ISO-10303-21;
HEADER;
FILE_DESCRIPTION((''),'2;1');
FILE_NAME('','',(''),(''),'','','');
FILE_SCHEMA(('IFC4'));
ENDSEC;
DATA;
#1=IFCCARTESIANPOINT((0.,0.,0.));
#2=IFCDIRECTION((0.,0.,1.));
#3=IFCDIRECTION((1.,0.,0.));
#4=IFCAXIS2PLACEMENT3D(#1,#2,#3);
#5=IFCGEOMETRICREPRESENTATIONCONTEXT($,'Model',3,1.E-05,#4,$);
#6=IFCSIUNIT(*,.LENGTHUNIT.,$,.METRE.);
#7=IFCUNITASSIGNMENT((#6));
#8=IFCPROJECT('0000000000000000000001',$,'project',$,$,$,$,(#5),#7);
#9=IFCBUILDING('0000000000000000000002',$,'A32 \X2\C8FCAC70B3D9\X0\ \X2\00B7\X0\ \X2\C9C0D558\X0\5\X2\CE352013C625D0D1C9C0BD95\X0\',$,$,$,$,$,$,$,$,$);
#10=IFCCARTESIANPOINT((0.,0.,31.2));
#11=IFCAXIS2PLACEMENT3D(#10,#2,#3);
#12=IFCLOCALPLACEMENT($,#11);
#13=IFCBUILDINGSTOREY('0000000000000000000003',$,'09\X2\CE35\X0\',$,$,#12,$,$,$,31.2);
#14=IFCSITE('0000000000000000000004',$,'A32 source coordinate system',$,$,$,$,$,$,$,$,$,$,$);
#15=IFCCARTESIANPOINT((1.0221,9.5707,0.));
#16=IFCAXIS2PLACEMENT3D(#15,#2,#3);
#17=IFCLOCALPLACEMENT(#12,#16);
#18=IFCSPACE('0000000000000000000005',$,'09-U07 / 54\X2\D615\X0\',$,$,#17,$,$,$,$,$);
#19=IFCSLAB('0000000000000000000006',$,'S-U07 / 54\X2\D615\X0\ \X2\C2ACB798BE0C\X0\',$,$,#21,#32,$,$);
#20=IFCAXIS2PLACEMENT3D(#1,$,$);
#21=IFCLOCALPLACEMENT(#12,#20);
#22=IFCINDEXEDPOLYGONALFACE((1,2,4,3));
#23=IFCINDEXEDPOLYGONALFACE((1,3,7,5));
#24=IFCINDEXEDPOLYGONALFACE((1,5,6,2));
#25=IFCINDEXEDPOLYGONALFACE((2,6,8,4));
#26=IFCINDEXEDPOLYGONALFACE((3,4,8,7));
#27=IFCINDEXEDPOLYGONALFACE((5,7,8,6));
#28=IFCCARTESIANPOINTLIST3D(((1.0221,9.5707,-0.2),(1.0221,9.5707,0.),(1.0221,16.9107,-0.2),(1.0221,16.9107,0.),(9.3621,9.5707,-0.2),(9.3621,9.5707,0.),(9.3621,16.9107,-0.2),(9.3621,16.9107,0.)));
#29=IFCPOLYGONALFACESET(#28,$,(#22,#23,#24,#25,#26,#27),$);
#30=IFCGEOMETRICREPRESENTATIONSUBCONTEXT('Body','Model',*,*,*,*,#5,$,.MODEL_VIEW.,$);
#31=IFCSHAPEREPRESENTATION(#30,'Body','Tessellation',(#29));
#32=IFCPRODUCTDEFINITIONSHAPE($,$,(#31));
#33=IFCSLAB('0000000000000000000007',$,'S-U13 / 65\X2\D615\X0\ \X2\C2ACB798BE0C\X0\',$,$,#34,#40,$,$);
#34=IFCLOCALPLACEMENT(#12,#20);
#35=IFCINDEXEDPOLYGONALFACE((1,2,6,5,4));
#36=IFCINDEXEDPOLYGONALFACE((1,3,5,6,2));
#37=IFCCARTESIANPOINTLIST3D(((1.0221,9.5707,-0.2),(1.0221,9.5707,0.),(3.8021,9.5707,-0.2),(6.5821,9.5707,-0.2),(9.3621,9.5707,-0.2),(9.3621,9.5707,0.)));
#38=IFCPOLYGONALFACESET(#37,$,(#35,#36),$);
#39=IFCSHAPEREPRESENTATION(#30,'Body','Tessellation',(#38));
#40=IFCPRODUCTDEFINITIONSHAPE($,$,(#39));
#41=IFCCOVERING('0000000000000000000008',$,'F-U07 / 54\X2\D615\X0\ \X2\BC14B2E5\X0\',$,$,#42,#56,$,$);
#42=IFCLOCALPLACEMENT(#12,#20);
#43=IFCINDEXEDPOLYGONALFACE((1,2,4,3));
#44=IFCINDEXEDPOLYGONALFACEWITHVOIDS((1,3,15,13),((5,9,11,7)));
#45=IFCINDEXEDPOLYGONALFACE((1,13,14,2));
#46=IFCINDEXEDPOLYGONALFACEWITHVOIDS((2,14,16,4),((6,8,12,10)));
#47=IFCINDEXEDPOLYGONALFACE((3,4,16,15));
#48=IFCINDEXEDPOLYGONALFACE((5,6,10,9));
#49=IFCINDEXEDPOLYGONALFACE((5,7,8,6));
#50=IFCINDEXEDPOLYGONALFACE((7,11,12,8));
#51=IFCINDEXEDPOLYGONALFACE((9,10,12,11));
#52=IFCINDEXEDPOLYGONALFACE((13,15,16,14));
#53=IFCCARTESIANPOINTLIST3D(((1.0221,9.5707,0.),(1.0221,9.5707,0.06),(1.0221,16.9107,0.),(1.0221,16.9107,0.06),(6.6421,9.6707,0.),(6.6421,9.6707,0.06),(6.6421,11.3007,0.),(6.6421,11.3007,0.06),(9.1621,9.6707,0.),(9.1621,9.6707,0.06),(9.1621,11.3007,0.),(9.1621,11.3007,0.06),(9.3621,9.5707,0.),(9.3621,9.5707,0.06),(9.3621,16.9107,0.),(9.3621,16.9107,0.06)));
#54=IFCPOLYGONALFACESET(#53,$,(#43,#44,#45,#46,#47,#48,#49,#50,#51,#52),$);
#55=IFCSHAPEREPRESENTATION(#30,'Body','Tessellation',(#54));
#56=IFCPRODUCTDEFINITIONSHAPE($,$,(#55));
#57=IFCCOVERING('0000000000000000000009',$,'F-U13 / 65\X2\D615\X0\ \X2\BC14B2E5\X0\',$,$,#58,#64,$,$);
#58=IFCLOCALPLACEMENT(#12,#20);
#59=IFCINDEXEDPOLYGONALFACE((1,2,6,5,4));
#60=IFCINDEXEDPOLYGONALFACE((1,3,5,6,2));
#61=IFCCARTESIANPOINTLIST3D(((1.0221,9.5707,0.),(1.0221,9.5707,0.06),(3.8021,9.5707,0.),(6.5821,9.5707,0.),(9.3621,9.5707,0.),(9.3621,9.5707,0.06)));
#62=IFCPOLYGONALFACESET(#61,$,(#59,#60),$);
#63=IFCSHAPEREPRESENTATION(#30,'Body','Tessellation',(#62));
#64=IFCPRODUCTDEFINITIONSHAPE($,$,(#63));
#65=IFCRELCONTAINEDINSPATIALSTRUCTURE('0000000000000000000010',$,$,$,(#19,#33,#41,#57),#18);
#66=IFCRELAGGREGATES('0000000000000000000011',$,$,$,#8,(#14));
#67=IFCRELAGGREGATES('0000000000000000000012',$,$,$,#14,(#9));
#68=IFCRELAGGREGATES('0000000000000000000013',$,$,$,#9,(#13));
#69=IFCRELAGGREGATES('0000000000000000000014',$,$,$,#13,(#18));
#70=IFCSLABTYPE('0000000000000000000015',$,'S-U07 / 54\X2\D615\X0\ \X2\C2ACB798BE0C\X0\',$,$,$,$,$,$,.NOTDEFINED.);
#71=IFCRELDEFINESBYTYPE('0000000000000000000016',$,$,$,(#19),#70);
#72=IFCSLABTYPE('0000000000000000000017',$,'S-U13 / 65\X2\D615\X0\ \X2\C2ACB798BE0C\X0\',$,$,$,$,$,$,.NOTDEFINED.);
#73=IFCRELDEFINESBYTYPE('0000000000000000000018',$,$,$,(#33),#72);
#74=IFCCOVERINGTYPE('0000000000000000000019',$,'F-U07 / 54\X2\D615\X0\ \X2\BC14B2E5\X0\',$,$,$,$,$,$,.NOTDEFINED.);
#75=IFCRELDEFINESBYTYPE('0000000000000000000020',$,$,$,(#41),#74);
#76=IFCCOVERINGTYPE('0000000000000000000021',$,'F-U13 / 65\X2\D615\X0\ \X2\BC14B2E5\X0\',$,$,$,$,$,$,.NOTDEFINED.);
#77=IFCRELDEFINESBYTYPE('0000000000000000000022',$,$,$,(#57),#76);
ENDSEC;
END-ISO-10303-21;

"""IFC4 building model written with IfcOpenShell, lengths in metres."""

from ifc_helpers import new_model, si_unit, frame, origin, origin_with_axes, place, context, subcontext, project, spatial, polyline, outline, extrude, source, transform, mapped, type_object, type_shapes, element, save


model = new_model("IFC4")

# Units and contexts
model_context = context("Model", 3, precision=1e-05, world=origin_with_axes())
body_context = subcontext(model_context, "Body", "Model", "MODEL_VIEW")
ifc_project = project(units=[si_unit("LENGTHUNIT", "METRE")], contexts=[model_context])

# Site, building, storey, space
storey_placement = place(None, frame((0.0, 0.0, 31.2), z_axis=(0.0, 0.0, 1.0), x_axis=(1.0, 0.0, 0.0)))
space_placement = place(storey_placement, frame((1.0221, 9.5707, 0.0), z_axis=(0.0, 0.0, 1.0), x_axis=(1.0, 0.0, 0.0)))
site = spatial("IfcSite", under=ifc_project, Name="A32 source coordinate system")
building = spatial("IfcBuilding", under=site, Name="A32 주거동 · 지하5층–옥탑지붕")
storey = spatial("IfcBuildingStorey", under=building, at=storey_placement, Name="09층", Elevation=31.2)
space = spatial("IfcSpace", under=storey, at=space_placement, Name="09-U07 / 54형")

# Slabs
slab_type_1 = type_object("IfcSlabType", Name="S-U07 / 54형 슬래브", PredefinedType="NOTDEFINED")
shared_shape_1 = source(origin(), body_context, "Body", "SweptSolid", [
    extrude(outline(polyline([(0.0, 0.0), (0.0, 7.34), (8.34, 7.34), (8.34, 0.0), (0.0, 0.0)])), frame((0.0, 0.0, -0.2)), (0.0, 0.0, 1.0), 0.2),
])
type_shapes(slab_type_1, [shared_shape_1])
slab_1_placement = place(space_placement, origin_with_axes())
element("IfcSlab", 1, at=slab_1_placement, inside=space, type_object=slab_type_1, Name="S-U07 / 54형 슬래브", context=body_context, shape_type="MappedRepresentation", body=[
    mapped(shared_shape_1, transform((0.0, 0.0, 0.0), scale=1.0)),
])
slab_type_2 = type_object("IfcSlabType", Name="S-U13 / 65형 슬래브", PredefinedType="NOTDEFINED")
shared_shape_2 = source(origin(), body_context, "Body", "SweptSolid", [
    extrude(outline(polyline([(0.0, 0.0), (8.34, 0.0), (8.34, 0.0), (0.0, 0.0), (0.0, 0.0)])), frame((0.0, 0.0, -0.2)), (0.0, 0.0, 1.0), 0.2),
])
type_shapes(slab_type_2, [shared_shape_2])
slab_2_placement = place(space_placement, origin_with_axes())
element("IfcSlab", 2, at=slab_2_placement, inside=space, type_object=slab_type_2, Name="S-U13 / 65형 슬래브", context=body_context, shape_type="MappedRepresentation", body=[
    mapped(shared_shape_2, transform((0.0, 0.0, 0.0), scale=1.0)),
])

# Coverings
covering_type_1 = type_object("IfcCoveringType", Name="F-U07 / 54형 바닥", PredefinedType="NOTDEFINED")
shared_shape_3 = source(origin(), body_context, "Body", "SweptSolid", [
    extrude(outline(polyline([(0.0, 0.0), (0.0, 7.34), (8.34, 7.34), (8.34, 0.0), (0.0, 0.0)]), holes=[polyline([(5.62, 1.73), (5.62, 0.1), (8.14, 0.1), (8.14, 1.73), (5.62, 1.73)])]), origin(), (0.0, 0.0, 1.0), 0.06),
])
type_shapes(covering_type_1, [shared_shape_3])
covering_1_placement = place(space_placement, origin_with_axes())
element("IfcCovering", 3, at=covering_1_placement, inside=space, type_object=covering_type_1, Name="F-U07 / 54형 바닥", context=body_context, shape_type="MappedRepresentation", body=[
    mapped(shared_shape_3, transform((0.0, 0.0, 0.0), scale=1.0)),
])
covering_type_2 = type_object("IfcCoveringType", Name="F-U13 / 65형 바닥", PredefinedType="NOTDEFINED")
shared_shape_4 = source(origin(), body_context, "Body", "SweptSolid", [
    extrude(outline(polyline([(0.0, 0.0), (8.34, 0.0), (8.34, 0.0), (0.0, 0.0), (0.0, 0.0)])), origin(), (0.0, 0.0, 1.0), 0.06),
])
type_shapes(covering_type_2, [shared_shape_4])
covering_2_placement = place(space_placement, origin_with_axes())
element("IfcCovering", 4, at=covering_2_placement, inside=space, type_object=covering_type_2, Name="F-U13 / 65형 바닥", context=body_context, shape_type="MappedRepresentation", body=[
    mapped(shared_shape_4, transform((0.0, 0.0, 0.0), scale=1.0)),
])

save(model, "model.ifc")
